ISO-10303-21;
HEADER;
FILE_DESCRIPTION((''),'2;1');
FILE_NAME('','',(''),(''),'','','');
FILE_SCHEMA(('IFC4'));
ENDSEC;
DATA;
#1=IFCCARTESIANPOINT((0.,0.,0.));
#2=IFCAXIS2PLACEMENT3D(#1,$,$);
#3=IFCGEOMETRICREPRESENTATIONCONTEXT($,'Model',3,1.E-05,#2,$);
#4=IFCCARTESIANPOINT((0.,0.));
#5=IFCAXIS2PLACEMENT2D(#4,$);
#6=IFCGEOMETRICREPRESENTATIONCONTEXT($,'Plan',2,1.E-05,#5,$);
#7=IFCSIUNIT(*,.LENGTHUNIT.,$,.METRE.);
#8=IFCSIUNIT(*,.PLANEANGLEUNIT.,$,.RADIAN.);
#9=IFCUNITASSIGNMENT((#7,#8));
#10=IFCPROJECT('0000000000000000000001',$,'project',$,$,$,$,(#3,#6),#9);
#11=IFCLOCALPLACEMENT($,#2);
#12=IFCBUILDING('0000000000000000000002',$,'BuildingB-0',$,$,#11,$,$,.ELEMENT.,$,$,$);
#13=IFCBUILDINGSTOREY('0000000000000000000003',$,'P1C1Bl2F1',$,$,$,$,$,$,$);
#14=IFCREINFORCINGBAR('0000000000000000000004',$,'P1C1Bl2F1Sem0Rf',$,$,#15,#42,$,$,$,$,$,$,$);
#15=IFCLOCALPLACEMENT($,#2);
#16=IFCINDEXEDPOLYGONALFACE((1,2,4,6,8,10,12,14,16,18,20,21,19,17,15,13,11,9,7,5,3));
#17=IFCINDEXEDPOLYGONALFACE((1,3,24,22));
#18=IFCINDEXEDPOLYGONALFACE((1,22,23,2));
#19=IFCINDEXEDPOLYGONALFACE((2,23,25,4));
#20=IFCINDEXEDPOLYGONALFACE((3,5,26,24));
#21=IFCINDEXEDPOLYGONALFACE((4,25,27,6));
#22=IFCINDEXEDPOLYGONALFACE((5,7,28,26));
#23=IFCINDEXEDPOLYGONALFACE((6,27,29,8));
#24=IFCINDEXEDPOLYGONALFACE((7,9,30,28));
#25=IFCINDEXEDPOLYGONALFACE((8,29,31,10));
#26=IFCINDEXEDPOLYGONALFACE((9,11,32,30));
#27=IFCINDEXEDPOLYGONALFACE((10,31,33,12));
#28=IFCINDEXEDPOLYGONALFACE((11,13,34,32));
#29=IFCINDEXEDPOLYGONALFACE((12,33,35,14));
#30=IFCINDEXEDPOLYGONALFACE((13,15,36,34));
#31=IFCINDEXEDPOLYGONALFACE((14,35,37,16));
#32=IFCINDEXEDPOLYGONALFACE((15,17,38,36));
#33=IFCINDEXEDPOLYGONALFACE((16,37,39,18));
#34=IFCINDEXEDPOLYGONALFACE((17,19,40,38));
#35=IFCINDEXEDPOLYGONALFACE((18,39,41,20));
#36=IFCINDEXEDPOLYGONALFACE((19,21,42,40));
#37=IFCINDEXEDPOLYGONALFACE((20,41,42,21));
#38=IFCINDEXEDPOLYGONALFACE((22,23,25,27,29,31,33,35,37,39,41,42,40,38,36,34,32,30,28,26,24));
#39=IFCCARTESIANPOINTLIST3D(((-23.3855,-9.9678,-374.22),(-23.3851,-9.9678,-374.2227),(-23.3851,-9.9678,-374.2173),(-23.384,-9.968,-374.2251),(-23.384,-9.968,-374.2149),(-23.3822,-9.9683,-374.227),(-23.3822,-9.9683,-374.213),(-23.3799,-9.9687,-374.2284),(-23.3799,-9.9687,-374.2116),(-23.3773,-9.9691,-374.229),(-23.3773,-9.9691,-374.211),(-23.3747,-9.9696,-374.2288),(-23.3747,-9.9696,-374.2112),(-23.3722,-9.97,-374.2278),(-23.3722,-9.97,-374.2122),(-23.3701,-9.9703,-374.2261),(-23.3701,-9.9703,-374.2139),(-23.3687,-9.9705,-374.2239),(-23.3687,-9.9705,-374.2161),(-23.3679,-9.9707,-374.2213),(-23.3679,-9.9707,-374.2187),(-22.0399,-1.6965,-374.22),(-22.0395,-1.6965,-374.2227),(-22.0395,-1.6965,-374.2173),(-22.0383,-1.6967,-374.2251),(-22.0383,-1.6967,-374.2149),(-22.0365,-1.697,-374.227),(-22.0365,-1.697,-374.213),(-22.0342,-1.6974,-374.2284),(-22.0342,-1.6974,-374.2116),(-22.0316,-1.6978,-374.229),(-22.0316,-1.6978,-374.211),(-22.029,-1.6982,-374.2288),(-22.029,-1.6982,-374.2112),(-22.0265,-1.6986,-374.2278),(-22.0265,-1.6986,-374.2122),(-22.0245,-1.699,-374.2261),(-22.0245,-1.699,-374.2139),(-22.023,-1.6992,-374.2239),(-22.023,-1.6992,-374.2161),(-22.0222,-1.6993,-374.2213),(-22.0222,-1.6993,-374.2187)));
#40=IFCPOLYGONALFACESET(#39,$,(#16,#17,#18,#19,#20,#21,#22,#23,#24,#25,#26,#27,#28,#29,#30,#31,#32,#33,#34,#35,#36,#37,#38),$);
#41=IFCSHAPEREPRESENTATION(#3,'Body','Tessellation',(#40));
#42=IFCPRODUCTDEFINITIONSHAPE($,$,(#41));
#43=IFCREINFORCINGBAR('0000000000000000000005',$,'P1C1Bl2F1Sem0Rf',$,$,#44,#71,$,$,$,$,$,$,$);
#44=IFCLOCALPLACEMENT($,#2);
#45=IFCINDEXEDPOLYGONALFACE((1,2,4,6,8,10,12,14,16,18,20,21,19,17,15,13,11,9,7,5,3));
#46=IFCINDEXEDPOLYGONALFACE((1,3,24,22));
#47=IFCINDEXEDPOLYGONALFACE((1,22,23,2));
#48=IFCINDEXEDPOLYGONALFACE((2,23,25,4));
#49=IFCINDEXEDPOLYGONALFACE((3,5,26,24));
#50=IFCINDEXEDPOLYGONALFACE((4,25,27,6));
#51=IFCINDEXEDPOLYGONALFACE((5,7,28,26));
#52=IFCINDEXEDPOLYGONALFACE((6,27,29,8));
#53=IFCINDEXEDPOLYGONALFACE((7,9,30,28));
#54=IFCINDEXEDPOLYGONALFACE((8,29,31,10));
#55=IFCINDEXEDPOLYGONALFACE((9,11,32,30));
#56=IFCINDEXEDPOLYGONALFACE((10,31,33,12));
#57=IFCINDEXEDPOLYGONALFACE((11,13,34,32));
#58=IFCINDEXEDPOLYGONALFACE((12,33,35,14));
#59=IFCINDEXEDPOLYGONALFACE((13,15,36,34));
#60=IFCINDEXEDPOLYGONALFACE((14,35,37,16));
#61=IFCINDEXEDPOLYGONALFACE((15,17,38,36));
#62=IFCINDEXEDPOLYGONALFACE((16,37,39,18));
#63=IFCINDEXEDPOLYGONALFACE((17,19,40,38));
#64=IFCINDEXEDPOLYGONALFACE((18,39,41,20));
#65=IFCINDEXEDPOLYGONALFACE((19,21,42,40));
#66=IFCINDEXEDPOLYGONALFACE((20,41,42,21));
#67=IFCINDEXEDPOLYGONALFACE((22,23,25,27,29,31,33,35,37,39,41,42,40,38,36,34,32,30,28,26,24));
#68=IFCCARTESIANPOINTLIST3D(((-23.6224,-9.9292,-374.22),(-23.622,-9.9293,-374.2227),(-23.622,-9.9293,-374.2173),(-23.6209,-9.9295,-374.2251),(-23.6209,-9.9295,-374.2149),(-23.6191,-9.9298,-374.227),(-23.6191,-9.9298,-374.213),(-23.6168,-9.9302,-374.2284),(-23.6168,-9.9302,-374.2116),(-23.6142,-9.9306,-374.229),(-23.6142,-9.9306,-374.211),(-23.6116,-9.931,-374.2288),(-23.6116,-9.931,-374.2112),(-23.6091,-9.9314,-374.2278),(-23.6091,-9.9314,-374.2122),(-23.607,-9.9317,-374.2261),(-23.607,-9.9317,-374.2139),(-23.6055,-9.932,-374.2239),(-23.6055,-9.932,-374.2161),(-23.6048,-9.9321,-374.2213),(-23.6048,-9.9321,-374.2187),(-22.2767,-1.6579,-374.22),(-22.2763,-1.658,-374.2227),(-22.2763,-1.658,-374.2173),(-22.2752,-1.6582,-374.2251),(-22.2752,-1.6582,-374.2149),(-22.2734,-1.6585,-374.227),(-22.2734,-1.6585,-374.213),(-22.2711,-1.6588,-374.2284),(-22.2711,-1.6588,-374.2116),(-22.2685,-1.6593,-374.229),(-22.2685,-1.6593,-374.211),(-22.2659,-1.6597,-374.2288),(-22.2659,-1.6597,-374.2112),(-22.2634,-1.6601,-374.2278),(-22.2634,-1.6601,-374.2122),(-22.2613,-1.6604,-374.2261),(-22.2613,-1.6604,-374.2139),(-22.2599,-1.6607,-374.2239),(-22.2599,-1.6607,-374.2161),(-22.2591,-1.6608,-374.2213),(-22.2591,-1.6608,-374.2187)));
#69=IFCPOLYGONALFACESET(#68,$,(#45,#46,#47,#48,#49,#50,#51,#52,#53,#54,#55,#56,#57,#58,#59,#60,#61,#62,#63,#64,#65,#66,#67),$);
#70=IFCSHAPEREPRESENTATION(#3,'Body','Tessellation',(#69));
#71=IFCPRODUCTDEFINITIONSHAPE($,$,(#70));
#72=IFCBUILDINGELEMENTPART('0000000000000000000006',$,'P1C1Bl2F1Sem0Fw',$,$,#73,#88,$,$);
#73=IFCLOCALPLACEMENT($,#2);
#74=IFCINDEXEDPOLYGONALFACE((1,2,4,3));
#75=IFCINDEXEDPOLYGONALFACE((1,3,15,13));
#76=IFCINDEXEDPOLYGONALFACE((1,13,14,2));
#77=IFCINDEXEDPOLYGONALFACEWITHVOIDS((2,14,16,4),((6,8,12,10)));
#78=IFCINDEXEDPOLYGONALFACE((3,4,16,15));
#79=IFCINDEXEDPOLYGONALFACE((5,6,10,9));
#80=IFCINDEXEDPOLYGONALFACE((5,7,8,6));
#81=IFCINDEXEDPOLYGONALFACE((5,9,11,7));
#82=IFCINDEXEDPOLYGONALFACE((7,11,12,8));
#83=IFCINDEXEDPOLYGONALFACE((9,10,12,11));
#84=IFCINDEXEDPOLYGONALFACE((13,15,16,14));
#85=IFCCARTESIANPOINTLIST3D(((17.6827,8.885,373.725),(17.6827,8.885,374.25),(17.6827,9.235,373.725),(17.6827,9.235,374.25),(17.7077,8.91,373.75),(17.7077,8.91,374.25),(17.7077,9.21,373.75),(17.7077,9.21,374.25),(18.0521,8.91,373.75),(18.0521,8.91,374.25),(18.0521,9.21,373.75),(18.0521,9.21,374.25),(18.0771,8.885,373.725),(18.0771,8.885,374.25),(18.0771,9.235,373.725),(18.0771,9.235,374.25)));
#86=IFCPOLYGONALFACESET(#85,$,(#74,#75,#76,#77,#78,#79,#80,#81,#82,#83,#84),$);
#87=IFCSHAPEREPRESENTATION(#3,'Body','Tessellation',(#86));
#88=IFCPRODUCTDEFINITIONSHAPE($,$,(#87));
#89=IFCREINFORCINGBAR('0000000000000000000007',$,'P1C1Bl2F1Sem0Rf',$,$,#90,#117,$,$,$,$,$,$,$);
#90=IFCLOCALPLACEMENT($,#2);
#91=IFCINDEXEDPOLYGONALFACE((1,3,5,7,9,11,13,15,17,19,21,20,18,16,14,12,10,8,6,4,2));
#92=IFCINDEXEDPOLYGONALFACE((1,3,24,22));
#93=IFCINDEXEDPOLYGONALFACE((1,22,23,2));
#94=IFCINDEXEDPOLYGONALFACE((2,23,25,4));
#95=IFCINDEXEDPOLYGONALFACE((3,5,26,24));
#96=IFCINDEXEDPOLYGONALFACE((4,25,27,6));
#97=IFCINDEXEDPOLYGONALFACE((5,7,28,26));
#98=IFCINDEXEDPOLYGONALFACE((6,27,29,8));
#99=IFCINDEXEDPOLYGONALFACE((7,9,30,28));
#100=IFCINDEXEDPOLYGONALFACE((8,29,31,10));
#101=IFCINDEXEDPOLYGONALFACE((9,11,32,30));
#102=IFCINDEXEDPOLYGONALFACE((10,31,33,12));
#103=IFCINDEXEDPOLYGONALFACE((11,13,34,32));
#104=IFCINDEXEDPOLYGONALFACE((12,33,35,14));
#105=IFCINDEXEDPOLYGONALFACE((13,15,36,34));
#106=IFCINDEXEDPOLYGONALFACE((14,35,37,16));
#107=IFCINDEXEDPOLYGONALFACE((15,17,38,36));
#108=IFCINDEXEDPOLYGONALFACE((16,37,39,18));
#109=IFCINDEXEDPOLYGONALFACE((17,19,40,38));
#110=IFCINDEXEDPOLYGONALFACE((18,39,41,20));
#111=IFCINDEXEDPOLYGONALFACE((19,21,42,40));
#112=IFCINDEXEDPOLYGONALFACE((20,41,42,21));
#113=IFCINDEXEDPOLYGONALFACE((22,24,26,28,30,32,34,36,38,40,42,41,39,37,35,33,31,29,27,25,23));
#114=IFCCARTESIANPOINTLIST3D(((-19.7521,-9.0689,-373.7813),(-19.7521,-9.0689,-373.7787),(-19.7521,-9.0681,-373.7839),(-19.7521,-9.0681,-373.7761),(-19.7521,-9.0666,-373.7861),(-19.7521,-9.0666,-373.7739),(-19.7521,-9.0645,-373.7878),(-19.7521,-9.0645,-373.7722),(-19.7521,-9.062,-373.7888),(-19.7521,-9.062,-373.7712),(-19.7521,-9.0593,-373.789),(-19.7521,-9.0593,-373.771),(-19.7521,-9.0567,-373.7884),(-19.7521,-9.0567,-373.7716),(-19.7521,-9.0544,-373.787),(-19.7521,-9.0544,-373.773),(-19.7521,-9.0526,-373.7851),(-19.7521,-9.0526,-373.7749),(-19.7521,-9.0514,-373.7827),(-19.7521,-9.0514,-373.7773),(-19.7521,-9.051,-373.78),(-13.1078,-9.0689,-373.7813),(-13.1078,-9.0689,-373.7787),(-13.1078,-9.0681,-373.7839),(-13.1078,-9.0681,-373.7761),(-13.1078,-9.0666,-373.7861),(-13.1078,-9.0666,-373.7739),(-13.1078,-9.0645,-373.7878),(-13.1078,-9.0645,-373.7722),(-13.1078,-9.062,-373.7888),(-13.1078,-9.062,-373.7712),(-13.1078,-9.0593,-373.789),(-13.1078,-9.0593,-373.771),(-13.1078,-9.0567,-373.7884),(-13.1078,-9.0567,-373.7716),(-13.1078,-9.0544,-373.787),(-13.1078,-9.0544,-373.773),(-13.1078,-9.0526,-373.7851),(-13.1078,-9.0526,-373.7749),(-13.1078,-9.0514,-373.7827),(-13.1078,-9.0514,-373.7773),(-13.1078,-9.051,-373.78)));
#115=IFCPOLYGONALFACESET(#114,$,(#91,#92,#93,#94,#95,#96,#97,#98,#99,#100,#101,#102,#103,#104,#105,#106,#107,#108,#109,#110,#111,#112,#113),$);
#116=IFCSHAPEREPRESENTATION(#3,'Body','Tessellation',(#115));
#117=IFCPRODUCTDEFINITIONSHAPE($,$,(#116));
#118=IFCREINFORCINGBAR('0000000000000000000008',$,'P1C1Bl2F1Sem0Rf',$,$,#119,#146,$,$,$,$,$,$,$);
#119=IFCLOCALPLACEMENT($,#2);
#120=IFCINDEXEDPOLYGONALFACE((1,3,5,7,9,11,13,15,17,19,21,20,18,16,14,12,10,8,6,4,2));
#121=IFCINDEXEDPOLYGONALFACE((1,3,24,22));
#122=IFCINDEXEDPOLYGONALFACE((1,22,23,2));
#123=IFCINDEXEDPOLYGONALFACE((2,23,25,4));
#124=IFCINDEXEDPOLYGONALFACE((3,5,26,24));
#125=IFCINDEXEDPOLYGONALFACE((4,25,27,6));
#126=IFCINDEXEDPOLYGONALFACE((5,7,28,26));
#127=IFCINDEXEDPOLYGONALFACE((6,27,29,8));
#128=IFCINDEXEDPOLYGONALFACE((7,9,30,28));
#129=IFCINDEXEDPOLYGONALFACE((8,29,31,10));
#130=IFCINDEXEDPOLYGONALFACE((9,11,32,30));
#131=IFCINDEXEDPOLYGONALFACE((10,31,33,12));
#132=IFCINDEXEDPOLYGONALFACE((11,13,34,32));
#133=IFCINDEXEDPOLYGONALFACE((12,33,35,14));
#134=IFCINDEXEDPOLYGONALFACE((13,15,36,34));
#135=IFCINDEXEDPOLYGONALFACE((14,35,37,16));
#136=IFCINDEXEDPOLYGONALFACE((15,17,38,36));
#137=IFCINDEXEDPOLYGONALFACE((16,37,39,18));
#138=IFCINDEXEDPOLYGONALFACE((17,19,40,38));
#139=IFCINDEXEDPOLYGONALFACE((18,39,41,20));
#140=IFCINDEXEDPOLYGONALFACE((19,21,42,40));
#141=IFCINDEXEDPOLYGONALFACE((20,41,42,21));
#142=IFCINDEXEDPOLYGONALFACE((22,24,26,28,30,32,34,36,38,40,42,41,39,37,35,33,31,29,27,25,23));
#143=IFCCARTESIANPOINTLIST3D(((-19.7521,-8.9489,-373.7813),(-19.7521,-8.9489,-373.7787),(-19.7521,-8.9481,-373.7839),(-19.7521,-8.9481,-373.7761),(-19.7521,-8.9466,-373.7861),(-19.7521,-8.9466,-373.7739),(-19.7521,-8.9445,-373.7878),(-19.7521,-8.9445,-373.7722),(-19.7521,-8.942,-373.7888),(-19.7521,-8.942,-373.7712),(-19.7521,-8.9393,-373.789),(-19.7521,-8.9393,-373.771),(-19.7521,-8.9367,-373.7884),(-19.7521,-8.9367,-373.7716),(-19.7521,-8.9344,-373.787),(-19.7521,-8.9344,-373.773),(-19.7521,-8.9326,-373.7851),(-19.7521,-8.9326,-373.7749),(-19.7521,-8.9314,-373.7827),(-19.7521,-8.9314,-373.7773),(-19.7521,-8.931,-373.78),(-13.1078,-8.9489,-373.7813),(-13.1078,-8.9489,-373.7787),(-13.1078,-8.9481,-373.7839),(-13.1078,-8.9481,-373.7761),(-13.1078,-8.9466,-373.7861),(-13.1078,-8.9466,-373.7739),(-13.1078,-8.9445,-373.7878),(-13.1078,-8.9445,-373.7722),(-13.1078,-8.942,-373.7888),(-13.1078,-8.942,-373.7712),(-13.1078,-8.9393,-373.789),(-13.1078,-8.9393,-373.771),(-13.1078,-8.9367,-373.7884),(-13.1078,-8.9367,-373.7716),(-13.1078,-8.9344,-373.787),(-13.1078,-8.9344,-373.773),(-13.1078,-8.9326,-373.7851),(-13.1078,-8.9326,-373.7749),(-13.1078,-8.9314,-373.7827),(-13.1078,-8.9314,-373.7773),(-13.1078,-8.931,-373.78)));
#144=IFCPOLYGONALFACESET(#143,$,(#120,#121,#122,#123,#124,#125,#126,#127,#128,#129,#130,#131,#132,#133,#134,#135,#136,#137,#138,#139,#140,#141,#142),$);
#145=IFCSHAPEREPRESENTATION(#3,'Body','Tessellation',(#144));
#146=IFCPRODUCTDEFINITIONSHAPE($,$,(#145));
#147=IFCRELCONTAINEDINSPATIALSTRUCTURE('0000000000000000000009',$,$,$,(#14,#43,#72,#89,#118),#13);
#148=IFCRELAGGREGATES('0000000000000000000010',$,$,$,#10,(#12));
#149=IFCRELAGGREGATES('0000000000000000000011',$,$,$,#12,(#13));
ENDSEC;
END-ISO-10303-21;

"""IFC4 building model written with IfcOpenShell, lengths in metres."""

from ifc_helpers import new_model, entity, si_unit, origin, origin_2d, place, context, project, spatial, polyline, outline, extrude, element, save


model = new_model("IFC4")

# Units and contexts
model_context = context("Model", 3, precision=1e-05, world=origin())
plan_context = context("Plan", 2, precision=1e-05, world=origin_2d())
ifc_project = project(units=[si_unit("LENGTHUNIT", "METRE"), si_unit("PLANEANGLEUNIT", "RADIAN")], contexts=[model_context, plan_context])

# Building, storey
building_placement = place(None, origin())
building = spatial("IfcBuilding", under=ifc_project, at=building_placement, Name="BuildingB-0", CompositionType="ELEMENT")
storey = spatial("IfcBuildingStorey", under=building, Name="P1C1Bl2F1")

# Reinforcing bars
element("IfcReinforcingBar", 1, inside=storey, Name="P1C1Bl2F1Sem0Rf", context=model_context, shape_type="SweptSolid", body=[
    entity("IfcSurfaceCurveSweptAreaSolid", entity("IfcCircleProfileDef", "AREA", None, None, 0.009), None, entity("IfcPolyline", [entity("IfcCartesianPoint", [23.3767, 9.9692, 374.22]), entity("IfcCartesianPoint", [22.031, 1.6979, 374.22])]), None, None, entity("IfcPlane", entity("IfcAxis2Placement3D", entity("IfcCartesianPoint", [23.3767, 9.9692, 374.22]), entity("IfcDirection", [0.0, 0.0, 1.0]), entity("IfcDirection", [1.0, 0.0, 0.0])))),
])
element("IfcReinforcingBar", 2, inside=storey, Name="P1C1Bl2F1Sem0Rf", context=model_context, shape_type="SweptSolid", body=[
    entity("IfcSurfaceCurveSweptAreaSolid", entity("IfcCircleProfileDef", "AREA", None, None, 0.009), None, entity("IfcPolyline", [entity("IfcCartesianPoint", [23.6135, 9.9307, 374.22]), entity("IfcCartesianPoint", [22.2679, 1.6594, 374.22])]), None, None, entity("IfcPlane", entity("IfcAxis2Placement3D", entity("IfcCartesianPoint", [23.6135, 9.9307, 374.22]), entity("IfcDirection", [0.0, 0.0, 1.0]), entity("IfcDirection", [1.0, 0.0, 0.0])))),
])

# Building element part, opening
building_element_part_1 = element("IfcBuildingElementPart", 3, inside=storey, Name="P1C1Bl2F1Sem0Fw", context=model_context, shape_type="SweptSolid", body=[
    extrude(outline(polyline([(17.6827, 8.885, 373.725), (17.6827, 9.235, 373.725), (18.0771, 9.235, 373.725), (18.0771, 8.885, 373.725), (17.6827, 8.885, 373.725)])), None, (0.0, 0.0, 1.0), 0.525),
])
element("IfcOpeningElement", 4, inside=storey, cuts=building_element_part_1, context=model_context, shape_type="SweptSolid", body=[
    extrude(outline(polyline([(17.7077, 8.91, 373.75), (17.7077, 9.21, 373.75), (18.0521, 9.21, 373.75), (18.0521, 8.91, 373.75), (17.7077, 8.91, 373.75)])), None, (0.0, 0.0, 1.0), 0.5),
])

# Reinforcing bars
element("IfcReinforcingBar", 5, inside=storey, Name="P1C1Bl2F1Sem0Rf", context=model_context, shape_type="SweptSolid", body=[
    entity("IfcSurfaceCurveSweptAreaSolid", entity("IfcCircleProfileDef", "AREA", None, None, 0.009), None, entity("IfcPolyline", [entity("IfcCartesianPoint", [13.1078, 9.06, 373.78]), entity("IfcCartesianPoint", [19.7521, 9.06, 373.78])]), None, None, entity("IfcPlane", entity("IfcAxis2Placement3D", entity("IfcCartesianPoint", [13.1078, 9.06, 373.78]), entity("IfcDirection", [0.0, 0.0, 1.0]), entity("IfcDirection", [1.0, 0.0, 0.0])))),
])
element("IfcReinforcingBar", 6, inside=storey, Name="P1C1Bl2F1Sem0Rf", context=model_context, shape_type="SweptSolid", body=[
    entity("IfcSurfaceCurveSweptAreaSolid", entity("IfcCircleProfileDef", "AREA", None, None, 0.009), None, entity("IfcPolyline", [entity("IfcCartesianPoint", [13.1078, 8.94, 373.78]), entity("IfcCartesianPoint", [19.7521, 8.94, 373.78])]), None, None, entity("IfcPlane", entity("IfcAxis2Placement3D", entity("IfcCartesianPoint", [13.1078, 8.94, 373.78]), entity("IfcDirection", [0.0, 0.0, 1.0]), entity("IfcDirection", [1.0, 0.0, 0.0])))),
])

save(model, "model.ifc")
